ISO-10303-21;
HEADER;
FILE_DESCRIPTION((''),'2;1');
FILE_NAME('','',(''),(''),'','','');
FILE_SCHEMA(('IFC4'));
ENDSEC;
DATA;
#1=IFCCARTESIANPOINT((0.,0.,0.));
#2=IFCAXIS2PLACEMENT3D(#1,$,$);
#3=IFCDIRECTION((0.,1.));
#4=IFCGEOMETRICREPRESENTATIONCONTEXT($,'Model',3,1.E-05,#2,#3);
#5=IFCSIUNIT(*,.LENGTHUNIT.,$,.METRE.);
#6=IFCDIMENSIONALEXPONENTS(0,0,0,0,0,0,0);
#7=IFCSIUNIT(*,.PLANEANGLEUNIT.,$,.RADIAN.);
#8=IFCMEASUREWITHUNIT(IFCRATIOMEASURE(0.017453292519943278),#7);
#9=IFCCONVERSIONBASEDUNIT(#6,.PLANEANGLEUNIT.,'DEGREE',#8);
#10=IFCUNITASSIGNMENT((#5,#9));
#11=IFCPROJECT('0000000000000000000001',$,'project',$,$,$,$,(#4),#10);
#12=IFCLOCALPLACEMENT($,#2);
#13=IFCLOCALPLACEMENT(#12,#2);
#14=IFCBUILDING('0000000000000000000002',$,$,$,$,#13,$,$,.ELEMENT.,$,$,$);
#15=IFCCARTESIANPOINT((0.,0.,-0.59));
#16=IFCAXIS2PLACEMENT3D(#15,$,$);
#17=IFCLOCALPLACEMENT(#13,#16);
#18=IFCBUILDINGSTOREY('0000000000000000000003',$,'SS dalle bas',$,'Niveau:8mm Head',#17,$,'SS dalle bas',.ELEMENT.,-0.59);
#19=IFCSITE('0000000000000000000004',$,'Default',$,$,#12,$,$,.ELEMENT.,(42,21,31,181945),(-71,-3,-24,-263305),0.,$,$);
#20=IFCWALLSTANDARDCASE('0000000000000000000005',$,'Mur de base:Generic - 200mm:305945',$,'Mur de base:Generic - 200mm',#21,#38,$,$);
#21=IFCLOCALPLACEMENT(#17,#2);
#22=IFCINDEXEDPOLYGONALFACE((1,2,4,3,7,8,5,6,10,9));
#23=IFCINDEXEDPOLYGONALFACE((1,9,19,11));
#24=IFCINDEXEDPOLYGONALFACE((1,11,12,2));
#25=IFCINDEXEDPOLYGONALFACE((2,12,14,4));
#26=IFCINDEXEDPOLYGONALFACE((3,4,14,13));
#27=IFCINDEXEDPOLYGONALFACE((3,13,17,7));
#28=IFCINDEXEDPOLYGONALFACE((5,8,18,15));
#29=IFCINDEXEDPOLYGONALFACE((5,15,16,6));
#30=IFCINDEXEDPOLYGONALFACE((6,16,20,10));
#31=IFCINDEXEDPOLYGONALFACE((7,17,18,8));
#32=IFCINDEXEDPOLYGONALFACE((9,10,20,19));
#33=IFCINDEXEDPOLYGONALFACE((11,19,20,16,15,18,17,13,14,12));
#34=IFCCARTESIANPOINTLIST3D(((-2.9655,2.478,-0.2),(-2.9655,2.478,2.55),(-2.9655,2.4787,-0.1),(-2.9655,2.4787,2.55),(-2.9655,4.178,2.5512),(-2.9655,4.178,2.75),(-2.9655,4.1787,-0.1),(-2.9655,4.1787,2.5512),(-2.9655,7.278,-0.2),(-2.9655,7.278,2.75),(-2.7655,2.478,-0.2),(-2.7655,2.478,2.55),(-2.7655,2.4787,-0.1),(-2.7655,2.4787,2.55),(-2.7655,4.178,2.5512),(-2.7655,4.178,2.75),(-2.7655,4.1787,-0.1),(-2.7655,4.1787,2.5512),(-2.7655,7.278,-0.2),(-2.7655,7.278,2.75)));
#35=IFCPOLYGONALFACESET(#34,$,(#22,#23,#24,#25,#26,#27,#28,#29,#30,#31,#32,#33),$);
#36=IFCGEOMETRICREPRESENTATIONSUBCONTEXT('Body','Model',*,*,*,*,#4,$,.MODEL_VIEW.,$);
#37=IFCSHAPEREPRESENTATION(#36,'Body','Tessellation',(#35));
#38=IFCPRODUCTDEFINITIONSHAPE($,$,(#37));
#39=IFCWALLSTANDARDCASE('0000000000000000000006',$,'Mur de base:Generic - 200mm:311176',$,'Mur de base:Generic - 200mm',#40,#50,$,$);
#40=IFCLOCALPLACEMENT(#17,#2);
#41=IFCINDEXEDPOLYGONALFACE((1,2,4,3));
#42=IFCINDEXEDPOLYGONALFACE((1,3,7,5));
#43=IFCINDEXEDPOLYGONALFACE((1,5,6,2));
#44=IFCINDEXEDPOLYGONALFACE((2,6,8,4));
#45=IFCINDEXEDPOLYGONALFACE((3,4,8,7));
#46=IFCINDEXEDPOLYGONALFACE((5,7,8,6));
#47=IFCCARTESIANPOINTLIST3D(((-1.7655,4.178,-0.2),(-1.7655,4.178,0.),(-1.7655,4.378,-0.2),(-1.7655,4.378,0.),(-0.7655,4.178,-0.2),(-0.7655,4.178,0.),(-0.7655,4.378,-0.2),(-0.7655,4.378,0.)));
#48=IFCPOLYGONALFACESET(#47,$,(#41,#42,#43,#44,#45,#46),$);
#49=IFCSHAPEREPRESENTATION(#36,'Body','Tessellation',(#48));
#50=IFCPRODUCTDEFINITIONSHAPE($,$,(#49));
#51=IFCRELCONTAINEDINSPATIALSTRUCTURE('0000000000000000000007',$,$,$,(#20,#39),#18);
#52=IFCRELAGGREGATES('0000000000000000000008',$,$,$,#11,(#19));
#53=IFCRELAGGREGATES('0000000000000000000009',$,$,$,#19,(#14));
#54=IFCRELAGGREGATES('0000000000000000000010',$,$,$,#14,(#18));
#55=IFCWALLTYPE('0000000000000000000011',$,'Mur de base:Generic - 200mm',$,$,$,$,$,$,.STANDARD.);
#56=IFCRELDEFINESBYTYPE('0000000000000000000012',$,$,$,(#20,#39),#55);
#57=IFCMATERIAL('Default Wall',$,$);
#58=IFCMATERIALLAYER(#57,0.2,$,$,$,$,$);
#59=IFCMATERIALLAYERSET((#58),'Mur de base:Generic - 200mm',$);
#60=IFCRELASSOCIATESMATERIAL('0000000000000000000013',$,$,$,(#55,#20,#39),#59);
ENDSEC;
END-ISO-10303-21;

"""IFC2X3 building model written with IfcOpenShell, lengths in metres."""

from ifc_helpers import new_model, entity, si_unit, converted_unit, direction, frame, frame_2d, origin, origin_2d_with_axis, place, context, subcontext, project, spatial, polyline, rectangle, extrude, clip, bounded_halfspace, material, layer, layer_set, layer_usage, type_object, element, save


model = new_model("IFC2X3")

# Units and contexts
model_context = context("Model", 3, precision=1e-05, world=origin(), true_north=direction((0.0, 1.0)))
body_context = subcontext(model_context, "Body", "Model", "MODEL_VIEW")
ifc_project = project(units=[si_unit("LENGTHUNIT", "METRE"), converted_unit("PLANEANGLEUNIT", "DEGREE", entity("IfcRatioMeasure", 0.017453292519943278), si_unit("PLANEANGLEUNIT", "RADIAN"), dimensions=[0, 0, 0, 0, 0, 0, 0])], contexts=[model_context])

# Site, building, storey
site_placement = place(None, origin())
site = spatial("IfcSite", under=ifc_project, at=site_placement, Name="Default", CompositionType="ELEMENT", RefLatitude=(42, 21, 31, 181945), RefLongitude=(-71, -3, -24, -263305), RefElevation=0.0)
building_placement = place(site_placement, origin())
building = spatial("IfcBuilding", under=site, at=building_placement, CompositionType="ELEMENT")
storey_placement = place(building_placement, frame((0.0, 0.0, -0.59)))
storey = spatial("IfcBuildingStorey", under=building, at=storey_placement, Name="SS dalle bas", ObjectType="Niveau:8mm Head", LongName="SS dalle bas", CompositionType="ELEMENT", Elevation=-0.59)

# Shared definitions
ifc_material_1 = material(Name="Default Wall")
ifc_layer_1 = layer(ifc_material_1, 0.2)
ifc_layer_set_1 = layer_set([ifc_layer_1], Name="Mur de base:Generic - 200mm")
ifc_layer_usage_1 = layer_usage(ifc_layer_set_1, "AXIS2", "NEGATIVE", 0.1)
wall_type = type_object("IfcWallType", Name="Mur de base:Generic - 200mm", PredefinedType="STANDARD", material=ifc_layer_set_1)

# Wall, opening
wall_1_placement = place(storey_placement, frame((-2.8655, 7.278, -0.2), z_axis=(0.0, 0.0, 1.0), x_axis=(0.0, -1.0, 0.0)))
wall_1 = element("IfcWallStandardCase", 1, at=wall_1_placement, inside=storey, type_object=wall_type, material=ifc_layer_usage_1, Name="Mur de base:Generic - 200mm:305945", ObjectType="Mur de base:Generic - 200mm", context=body_context, shape_type="Clipping", body=[
    clip(clip(extrude(rectangle(XDim=4.8, YDim=0.2, at=frame_2d((2.4, 0.0), x_axis=(-1.0, 0.0))), origin(), (0.0, 0.0, 1.0), 2.95), bounded_halfspace(frame((4.7993, -0.1, 2.75), z_axis=(0.0, 0.0, -1.0), x_axis=(1.0, 0.0, 0.0)), True, frame((4.7993, -0.1, 2.75), z_axis=(0.0, 0.0, -1.0), x_axis=(1.0, 0.0, 0.0)), polyline([(0.0, 0.0), (0.0, -0.2), (0.0007, -0.2), (0.0007, 0.0), (0.0, 0.0)]))), bounded_halfspace(frame((3.1, -0.1, 2.95), z_axis=(-1.0, 0.0, 0.0), x_axis=(0.0, 0.0, 1.0)), True, frame((3.1, -0.1, 2.95), z_axis=(-1.0, 0.0, 0.0), x_axis=(0.0, 0.0, 1.0)), polyline([(0.0, 0.0), (0.0, 0.2), (-0.1988, 0.2), (-0.1988, 0.0), (0.0, 0.0)]))),
])
opening_1_placement = place(wall_1_placement, origin())
element("IfcOpeningElement", 2, at=opening_1_placement, cuts=wall_1, ObjectType="Opening", context=body_context, shape_type="SweptSolid", body=[
    extrude(rectangle(XDim=2.6512, YDim=1.7, at=origin_2d_with_axis()), frame((3.9493, -0.1, 1.4256), z_axis=(0.0, 1.0, 0.0), x_axis=(0.0, 0.0, -1.0)), (0.0, 0.0, 1.0), 0.2),
])

# Wall
wall_2_placement = place(storey_placement, frame((-0.7655, 4.278, -0.2), z_axis=(0.0, 0.0, 1.0), x_axis=(-1.0, 0.0, 0.0)))
element("IfcWallStandardCase", 3, at=wall_2_placement, inside=storey, type_object=wall_type, material=ifc_layer_usage_1, Name="Mur de base:Generic - 200mm:311176", ObjectType="Mur de base:Generic - 200mm", context=body_context, shape_type="SweptSolid", body=[
    extrude(rectangle(XDim=1.0, YDim=0.2, at=frame_2d((0.5, 0.0), x_axis=(-1.0, 0.0))), origin(), (0.0, 0.0, 1.0), 0.2),
])

save(model, "model.ifc")
